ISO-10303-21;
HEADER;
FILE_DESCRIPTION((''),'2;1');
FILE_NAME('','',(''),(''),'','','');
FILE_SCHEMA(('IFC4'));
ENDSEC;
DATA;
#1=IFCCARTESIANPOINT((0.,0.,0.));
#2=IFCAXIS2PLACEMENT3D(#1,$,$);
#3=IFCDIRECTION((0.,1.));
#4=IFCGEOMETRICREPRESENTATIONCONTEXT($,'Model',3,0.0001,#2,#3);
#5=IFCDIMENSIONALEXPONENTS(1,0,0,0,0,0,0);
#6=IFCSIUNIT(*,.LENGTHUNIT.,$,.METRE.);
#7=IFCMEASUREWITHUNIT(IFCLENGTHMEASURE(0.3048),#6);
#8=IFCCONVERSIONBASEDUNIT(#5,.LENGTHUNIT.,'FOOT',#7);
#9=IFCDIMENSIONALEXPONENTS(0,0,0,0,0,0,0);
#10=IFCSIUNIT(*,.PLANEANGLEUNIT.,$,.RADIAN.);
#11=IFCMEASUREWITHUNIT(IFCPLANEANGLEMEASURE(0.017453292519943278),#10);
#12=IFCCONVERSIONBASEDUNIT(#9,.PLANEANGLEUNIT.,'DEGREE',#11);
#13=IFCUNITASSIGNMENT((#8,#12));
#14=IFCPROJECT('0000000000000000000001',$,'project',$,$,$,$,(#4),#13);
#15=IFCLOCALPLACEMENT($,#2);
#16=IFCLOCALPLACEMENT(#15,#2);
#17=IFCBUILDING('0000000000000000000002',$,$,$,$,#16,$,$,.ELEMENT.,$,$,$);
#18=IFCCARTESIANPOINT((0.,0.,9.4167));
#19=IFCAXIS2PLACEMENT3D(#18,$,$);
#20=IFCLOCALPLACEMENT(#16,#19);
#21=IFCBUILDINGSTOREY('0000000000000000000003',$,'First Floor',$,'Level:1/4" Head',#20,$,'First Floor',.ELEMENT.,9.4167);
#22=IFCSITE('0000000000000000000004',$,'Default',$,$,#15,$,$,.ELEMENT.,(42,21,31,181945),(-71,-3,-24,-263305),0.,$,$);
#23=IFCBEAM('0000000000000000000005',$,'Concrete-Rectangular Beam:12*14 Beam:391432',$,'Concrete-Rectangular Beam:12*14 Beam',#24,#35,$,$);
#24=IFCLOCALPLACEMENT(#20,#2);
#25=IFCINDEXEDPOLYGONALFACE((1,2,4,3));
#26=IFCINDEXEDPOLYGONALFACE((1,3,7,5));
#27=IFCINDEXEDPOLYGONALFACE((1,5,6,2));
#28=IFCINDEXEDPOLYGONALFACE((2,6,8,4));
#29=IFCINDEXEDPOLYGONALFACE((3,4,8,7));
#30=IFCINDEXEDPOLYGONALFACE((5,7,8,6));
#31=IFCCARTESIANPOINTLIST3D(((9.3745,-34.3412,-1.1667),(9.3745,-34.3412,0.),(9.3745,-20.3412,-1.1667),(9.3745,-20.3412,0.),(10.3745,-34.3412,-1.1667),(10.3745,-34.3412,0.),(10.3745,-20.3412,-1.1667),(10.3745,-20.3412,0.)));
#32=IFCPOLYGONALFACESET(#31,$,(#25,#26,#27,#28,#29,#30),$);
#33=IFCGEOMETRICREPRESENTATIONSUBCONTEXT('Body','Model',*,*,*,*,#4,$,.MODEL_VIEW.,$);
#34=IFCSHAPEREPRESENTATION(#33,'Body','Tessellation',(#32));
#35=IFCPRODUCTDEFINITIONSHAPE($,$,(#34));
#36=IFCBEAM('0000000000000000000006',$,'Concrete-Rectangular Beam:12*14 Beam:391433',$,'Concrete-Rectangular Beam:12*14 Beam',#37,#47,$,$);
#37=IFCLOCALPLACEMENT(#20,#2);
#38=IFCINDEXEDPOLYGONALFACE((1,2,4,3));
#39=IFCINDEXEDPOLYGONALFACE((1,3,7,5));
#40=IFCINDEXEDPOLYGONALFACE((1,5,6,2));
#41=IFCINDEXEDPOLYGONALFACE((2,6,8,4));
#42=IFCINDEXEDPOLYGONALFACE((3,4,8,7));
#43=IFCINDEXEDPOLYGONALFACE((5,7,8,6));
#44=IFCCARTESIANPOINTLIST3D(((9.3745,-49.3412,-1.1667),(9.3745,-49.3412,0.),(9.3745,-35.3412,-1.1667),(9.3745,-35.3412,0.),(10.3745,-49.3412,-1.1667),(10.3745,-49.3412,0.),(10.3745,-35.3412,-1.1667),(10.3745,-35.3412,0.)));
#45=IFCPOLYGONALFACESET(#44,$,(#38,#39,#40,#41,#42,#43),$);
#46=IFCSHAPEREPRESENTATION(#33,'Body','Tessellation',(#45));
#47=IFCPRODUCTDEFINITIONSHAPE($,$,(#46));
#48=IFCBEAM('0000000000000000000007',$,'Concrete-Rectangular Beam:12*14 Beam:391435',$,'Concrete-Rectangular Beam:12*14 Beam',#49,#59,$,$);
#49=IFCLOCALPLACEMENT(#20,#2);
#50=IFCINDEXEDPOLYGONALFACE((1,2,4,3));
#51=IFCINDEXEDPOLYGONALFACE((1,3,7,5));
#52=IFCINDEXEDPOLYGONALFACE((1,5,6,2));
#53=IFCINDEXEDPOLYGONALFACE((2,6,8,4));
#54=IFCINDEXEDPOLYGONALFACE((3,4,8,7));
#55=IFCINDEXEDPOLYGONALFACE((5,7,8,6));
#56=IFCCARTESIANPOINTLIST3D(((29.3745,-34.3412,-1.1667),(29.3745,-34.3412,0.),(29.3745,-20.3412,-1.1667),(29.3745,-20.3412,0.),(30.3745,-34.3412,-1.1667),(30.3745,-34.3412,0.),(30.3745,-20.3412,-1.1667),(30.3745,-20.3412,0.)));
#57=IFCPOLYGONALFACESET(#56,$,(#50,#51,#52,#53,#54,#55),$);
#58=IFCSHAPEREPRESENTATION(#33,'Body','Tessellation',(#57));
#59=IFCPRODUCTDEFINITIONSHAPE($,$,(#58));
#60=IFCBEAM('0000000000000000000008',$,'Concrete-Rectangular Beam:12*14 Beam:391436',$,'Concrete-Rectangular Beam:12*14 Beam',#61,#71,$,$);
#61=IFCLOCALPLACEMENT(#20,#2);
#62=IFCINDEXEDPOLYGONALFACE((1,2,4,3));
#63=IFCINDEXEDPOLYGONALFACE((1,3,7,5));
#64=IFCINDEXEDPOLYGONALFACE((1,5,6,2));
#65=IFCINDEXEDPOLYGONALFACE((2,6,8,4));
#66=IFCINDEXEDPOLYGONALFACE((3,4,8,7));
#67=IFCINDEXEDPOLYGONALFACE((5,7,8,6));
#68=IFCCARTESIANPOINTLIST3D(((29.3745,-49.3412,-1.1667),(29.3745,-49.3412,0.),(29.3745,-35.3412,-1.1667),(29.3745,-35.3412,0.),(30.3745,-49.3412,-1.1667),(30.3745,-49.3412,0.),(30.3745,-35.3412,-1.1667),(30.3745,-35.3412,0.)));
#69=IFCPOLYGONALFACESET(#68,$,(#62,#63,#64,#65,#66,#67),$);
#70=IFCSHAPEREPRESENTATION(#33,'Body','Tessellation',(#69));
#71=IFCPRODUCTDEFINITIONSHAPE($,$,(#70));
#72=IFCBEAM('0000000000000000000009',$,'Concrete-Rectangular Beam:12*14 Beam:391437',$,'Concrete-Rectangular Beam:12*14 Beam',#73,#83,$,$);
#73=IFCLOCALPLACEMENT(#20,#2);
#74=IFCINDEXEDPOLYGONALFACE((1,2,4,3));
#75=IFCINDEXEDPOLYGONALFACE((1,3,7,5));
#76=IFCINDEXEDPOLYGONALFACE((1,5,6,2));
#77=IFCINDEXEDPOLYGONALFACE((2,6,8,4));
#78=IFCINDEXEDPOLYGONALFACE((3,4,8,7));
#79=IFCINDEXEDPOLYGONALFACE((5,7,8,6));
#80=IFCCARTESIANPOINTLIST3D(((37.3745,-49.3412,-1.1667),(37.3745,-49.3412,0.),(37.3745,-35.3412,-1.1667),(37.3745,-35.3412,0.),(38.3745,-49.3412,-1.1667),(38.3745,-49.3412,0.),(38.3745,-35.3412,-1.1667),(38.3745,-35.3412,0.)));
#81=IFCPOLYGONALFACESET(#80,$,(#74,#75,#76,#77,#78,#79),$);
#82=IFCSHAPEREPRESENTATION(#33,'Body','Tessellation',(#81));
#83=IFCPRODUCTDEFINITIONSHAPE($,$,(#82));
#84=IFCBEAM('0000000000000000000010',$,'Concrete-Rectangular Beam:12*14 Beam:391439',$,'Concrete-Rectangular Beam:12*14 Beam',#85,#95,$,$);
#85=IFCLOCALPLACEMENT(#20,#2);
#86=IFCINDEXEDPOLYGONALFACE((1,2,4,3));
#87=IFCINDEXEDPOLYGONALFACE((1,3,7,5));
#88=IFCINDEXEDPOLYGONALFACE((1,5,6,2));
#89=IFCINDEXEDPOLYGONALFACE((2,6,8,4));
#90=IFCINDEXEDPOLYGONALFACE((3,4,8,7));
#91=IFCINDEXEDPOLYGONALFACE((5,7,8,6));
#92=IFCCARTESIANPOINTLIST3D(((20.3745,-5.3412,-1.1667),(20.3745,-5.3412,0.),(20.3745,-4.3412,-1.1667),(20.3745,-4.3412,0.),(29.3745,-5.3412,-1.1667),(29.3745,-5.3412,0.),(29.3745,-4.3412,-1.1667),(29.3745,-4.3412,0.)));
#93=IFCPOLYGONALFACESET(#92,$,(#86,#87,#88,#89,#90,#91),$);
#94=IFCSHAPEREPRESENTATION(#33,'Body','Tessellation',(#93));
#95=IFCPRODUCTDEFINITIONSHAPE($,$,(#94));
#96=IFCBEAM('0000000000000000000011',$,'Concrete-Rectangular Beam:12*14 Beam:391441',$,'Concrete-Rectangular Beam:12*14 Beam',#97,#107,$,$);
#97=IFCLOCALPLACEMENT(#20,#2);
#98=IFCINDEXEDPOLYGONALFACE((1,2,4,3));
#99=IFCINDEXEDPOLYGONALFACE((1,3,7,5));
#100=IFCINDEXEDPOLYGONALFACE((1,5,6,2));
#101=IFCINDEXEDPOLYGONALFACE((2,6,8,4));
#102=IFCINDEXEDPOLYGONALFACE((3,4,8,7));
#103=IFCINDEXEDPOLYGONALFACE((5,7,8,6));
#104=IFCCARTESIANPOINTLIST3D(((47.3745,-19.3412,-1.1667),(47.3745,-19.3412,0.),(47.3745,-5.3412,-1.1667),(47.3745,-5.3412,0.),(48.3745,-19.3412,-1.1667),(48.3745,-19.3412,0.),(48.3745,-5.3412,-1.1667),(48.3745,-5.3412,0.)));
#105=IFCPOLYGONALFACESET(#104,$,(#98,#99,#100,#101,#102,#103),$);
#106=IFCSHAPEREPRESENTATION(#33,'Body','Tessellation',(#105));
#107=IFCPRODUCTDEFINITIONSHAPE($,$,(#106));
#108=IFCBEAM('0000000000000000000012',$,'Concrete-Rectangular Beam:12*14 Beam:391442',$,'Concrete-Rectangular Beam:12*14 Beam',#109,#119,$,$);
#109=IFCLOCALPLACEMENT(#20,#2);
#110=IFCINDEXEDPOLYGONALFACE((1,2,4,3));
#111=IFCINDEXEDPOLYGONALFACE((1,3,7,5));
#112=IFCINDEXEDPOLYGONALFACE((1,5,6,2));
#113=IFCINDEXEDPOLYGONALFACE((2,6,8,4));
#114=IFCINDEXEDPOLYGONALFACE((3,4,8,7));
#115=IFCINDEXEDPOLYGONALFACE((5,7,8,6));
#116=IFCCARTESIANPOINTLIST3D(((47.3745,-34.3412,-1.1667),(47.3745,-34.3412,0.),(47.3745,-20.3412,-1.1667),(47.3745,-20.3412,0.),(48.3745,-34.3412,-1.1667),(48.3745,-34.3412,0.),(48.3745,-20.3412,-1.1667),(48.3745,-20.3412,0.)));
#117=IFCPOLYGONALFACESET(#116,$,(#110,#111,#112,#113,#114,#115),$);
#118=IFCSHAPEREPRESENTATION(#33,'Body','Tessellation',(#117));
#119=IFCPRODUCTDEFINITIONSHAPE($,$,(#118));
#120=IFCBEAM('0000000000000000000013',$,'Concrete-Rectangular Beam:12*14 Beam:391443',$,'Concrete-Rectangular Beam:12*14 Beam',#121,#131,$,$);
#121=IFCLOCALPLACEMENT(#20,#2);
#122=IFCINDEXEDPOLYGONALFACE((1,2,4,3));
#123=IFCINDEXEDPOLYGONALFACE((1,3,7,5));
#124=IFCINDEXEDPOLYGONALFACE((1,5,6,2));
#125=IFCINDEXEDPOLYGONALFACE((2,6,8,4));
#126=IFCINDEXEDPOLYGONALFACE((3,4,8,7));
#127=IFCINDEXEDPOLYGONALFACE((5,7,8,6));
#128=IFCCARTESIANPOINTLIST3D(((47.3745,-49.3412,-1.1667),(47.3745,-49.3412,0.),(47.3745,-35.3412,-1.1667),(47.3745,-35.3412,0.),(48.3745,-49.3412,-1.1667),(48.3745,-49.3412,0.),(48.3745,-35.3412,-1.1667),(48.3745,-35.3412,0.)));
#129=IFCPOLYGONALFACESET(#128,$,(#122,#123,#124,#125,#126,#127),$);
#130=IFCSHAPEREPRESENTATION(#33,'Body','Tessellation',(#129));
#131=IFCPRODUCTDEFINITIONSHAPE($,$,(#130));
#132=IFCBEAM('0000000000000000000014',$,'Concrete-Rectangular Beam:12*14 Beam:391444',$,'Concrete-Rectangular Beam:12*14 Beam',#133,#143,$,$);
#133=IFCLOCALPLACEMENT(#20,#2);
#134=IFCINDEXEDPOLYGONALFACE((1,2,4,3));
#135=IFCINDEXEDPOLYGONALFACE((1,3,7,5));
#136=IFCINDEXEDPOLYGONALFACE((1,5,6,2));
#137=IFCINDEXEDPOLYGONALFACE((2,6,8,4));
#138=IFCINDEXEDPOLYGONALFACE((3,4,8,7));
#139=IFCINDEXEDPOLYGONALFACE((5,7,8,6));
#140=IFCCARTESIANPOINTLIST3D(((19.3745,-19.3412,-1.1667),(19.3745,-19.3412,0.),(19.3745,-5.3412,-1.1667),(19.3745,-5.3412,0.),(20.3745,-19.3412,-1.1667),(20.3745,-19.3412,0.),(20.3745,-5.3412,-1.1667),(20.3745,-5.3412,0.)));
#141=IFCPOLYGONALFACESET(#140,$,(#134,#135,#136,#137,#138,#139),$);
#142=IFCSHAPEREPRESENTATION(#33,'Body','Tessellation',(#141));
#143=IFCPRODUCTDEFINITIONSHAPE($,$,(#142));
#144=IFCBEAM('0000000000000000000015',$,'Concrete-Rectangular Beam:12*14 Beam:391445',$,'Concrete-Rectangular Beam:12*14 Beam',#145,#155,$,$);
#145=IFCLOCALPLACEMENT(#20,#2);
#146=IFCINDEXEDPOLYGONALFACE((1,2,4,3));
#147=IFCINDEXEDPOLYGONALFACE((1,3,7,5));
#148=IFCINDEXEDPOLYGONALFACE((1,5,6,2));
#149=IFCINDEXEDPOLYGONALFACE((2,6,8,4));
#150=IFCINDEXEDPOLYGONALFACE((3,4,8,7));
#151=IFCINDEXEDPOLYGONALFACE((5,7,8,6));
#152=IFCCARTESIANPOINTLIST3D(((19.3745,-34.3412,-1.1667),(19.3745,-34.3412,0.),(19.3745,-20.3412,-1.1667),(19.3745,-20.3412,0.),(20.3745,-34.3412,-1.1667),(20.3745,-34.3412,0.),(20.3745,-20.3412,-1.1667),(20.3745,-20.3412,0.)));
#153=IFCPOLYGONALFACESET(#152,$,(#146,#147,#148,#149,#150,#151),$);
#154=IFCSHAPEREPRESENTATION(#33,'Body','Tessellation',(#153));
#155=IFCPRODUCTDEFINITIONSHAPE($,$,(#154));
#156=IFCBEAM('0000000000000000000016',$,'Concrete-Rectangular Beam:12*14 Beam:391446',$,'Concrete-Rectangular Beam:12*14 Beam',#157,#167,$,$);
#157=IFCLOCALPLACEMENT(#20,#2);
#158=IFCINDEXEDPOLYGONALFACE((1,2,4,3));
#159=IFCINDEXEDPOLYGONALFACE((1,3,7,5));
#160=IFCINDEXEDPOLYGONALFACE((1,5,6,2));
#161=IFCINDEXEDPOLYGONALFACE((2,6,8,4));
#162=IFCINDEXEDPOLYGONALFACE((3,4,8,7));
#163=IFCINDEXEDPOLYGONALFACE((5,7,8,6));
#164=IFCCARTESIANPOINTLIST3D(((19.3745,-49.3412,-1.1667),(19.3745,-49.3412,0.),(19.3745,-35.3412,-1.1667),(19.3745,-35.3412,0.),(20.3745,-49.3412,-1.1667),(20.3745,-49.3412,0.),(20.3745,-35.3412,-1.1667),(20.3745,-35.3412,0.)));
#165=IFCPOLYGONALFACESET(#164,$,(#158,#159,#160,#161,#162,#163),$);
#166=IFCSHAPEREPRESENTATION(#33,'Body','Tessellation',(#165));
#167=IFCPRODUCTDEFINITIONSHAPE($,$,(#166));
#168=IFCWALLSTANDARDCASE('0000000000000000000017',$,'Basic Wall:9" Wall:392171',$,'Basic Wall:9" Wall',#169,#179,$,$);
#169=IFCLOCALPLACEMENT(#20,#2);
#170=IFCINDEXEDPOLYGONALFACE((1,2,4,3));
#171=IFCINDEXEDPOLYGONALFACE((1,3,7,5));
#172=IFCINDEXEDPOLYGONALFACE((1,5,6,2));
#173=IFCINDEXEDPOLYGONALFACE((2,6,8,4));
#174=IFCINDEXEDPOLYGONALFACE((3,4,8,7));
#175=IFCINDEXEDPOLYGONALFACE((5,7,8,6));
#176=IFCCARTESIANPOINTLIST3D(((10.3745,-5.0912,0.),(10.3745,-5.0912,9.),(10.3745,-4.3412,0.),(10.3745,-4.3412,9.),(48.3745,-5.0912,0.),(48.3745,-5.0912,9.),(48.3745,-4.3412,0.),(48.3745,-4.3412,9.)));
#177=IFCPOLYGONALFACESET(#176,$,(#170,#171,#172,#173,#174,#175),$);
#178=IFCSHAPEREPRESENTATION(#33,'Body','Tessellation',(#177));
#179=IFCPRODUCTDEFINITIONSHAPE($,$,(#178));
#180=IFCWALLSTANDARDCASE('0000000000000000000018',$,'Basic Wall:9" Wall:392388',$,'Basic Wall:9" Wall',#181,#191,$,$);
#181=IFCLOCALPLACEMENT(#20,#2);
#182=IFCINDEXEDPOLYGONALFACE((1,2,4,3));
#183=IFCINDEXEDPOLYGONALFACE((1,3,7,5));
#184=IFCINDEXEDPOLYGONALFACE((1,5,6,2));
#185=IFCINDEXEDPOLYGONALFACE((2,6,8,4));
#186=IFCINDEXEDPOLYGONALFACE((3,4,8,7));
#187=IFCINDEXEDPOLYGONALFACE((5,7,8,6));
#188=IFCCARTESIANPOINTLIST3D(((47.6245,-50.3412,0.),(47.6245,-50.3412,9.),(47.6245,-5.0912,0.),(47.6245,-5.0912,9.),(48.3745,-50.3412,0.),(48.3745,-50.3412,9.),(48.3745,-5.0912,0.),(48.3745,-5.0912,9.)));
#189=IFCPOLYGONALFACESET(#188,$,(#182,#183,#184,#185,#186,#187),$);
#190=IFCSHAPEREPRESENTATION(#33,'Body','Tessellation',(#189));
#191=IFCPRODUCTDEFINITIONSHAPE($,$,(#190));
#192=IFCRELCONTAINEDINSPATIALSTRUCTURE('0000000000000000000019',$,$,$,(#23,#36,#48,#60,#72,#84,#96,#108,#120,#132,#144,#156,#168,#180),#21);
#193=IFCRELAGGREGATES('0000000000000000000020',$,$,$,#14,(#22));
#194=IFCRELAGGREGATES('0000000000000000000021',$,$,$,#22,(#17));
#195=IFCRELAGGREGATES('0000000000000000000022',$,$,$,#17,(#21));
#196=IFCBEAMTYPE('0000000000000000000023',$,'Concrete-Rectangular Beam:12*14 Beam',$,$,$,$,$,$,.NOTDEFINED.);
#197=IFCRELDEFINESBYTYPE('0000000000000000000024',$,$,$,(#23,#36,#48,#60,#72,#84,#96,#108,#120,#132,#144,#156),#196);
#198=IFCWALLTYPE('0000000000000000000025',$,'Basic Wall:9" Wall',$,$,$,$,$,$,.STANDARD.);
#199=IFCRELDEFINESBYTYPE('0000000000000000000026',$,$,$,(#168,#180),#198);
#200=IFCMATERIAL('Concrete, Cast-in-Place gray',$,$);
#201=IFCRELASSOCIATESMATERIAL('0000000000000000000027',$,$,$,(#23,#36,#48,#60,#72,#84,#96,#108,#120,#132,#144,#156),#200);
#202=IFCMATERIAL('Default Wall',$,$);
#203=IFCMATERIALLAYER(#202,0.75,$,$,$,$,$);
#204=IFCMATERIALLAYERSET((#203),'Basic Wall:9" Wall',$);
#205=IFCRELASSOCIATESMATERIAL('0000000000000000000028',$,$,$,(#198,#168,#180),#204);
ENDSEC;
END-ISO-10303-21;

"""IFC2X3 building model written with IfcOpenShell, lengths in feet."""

from ifc_helpers import new_model, entity, si_unit, converted_unit, direction, frame, frame_2d, origin, place, context, subcontext, project, spatial, rectangle, extrude, material, layer, layer_set, layer_usage, type_object, element, save


model = new_model("IFC2X3")

# Units and contexts
model_context = context("Model", 3, precision=0.0001, world=origin(), true_north=direction((0.0, 1.0)))
body_context = subcontext(model_context, "Body", "Model", "MODEL_VIEW")
ifc_project = project(units=[converted_unit("LENGTHUNIT", "FOOT", entity("IfcLengthMeasure", 0.3048), si_unit("LENGTHUNIT", "METRE"), dimensions=[1, 0, 0, 0, 0, 0, 0]), converted_unit("PLANEANGLEUNIT", "DEGREE", entity("IfcPlaneAngleMeasure", 0.017453292519943278), si_unit("PLANEANGLEUNIT", "RADIAN"), dimensions=[0, 0, 0, 0, 0, 0, 0])], contexts=[model_context])

# Site, building, storey
site_placement = place(None, origin())
site = spatial("IfcSite", under=ifc_project, at=site_placement, Name="Default", CompositionType="ELEMENT", RefLatitude=(42, 21, 31, 181945), RefLongitude=(-71, -3, -24, -263305), RefElevation=0.0)
building_placement = place(site_placement, origin())
building = spatial("IfcBuilding", under=site, at=building_placement, CompositionType="ELEMENT")
storey_placement = place(building_placement, frame((0.0, 0.0, 9.4167)))
storey = spatial("IfcBuildingStorey", under=building, at=storey_placement, Name="First Floor", ObjectType="Level:1/4\" Head", LongName="First Floor", CompositionType="ELEMENT", Elevation=9.4167)

# Shared definitions
ifc_material_1 = material(Name="Concrete, Cast-in-Place gray")

# Beams
beam_type = type_object("IfcBeamType", Name="Concrete-Rectangular Beam:12*14 Beam", PredefinedType="NOTDEFINED")
beam_1_placement = place(storey_placement, frame((9.8745, -19.8412, 0.0), z_axis=(0.0, 0.0, 1.0), x_axis=(0.0, -1.0, 0.0)))
element("IfcBeam", 1, at=beam_1_placement, inside=storey, type_object=beam_type, material=ifc_material_1, Name="Concrete-Rectangular Beam:12*14 Beam:391432", ObjectType="Concrete-Rectangular Beam:12*14 Beam", context=body_context, shape_type="SweptSolid", body=[
    extrude(rectangle(XDim=1.1667, YDim=1.0, at=frame_2d((0.0, 0.0), x_axis=(1.0, 0.0))), frame((0.5, 0.0, -0.5833), z_axis=(1.0, 0.0, 0.0), x_axis=(0.0, 0.0, -1.0)), (0.0, 0.0, 1.0), 14.0),
])
beam_2_placement = place(storey_placement, frame((9.8745, -34.8412, 0.0), z_axis=(0.0, 0.0, 1.0), x_axis=(0.0, -1.0, 0.0)))
element("IfcBeam", 2, at=beam_2_placement, inside=storey, type_object=beam_type, material=ifc_material_1, Name="Concrete-Rectangular Beam:12*14 Beam:391433", ObjectType="Concrete-Rectangular Beam:12*14 Beam", context=body_context, shape_type="SweptSolid", body=[
    extrude(rectangle(XDim=1.1667, YDim=1.0, at=frame_2d((0.0, 0.0), x_axis=(1.0, 0.0))), frame((0.5, 0.0, -0.5833), z_axis=(1.0, 0.0, 0.0), x_axis=(0.0, 0.0, -1.0)), (0.0, 0.0, 1.0), 14.0),
])
beam_3_placement = place(storey_placement, frame((29.8745, -19.8412, 0.0), z_axis=(0.0, 0.0, 1.0), x_axis=(0.0, -1.0, 0.0)))
element("IfcBeam", 3, at=beam_3_placement, inside=storey, type_object=beam_type, material=ifc_material_1, Name="Concrete-Rectangular Beam:12*14 Beam:391435", ObjectType="Concrete-Rectangular Beam:12*14 Beam", context=body_context, shape_type="SweptSolid", body=[
    extrude(rectangle(XDim=1.1667, YDim=1.0, at=frame_2d((0.0, 0.0), x_axis=(1.0, 0.0))), frame((0.5, 0.0, -0.5833), z_axis=(1.0, 0.0, 0.0), x_axis=(0.0, 0.0, -1.0)), (0.0, 0.0, 1.0), 14.0),
])
beam_4_placement = place(storey_placement, frame((29.8745, -34.8412, 0.0), z_axis=(0.0, 0.0, 1.0), x_axis=(0.0, -1.0, 0.0)))
element("IfcBeam", 4, at=beam_4_placement, inside=storey, type_object=beam_type, material=ifc_material_1, Name="Concrete-Rectangular Beam:12*14 Beam:391436", ObjectType="Concrete-Rectangular Beam:12*14 Beam", context=body_context, shape_type="SweptSolid", body=[
    extrude(rectangle(XDim=1.1667, YDim=1.0, at=frame_2d((0.0, 0.0), x_axis=(1.0, 0.0))), frame((0.5, 0.0, -0.5833), z_axis=(1.0, 0.0, 0.0), x_axis=(0.0, 0.0, -1.0)), (0.0, 0.0, 1.0), 14.0),
])
beam_5_placement = place(storey_placement, frame((37.8745, -34.8412, 0.0), z_axis=(0.0, 0.0, 1.0), x_axis=(0.0, -1.0, 0.0)))
element("IfcBeam", 5, at=beam_5_placement, inside=storey, type_object=beam_type, material=ifc_material_1, Name="Concrete-Rectangular Beam:12*14 Beam:391437", ObjectType="Concrete-Rectangular Beam:12*14 Beam", context=body_context, shape_type="SweptSolid", body=[
    extrude(rectangle(XDim=1.1667, YDim=1.0, at=frame_2d((0.0, 0.0), x_axis=(1.0, 0.0))), frame((0.5, 0.0, -0.5833), z_axis=(1.0, 0.0, 0.0), x_axis=(0.0, 0.0, -1.0)), (0.0, 0.0, 1.0), 14.0),
])
beam_6_placement = place(storey_placement, frame((19.8745, -4.8412, 0.0)))
element("IfcBeam", 6, at=beam_6_placement, inside=storey, type_object=beam_type, material=ifc_material_1, Name="Concrete-Rectangular Beam:12*14 Beam:391439", ObjectType="Concrete-Rectangular Beam:12*14 Beam", context=body_context, shape_type="SweptSolid", body=[
    extrude(rectangle(XDim=1.1667, YDim=1.0, at=frame_2d((0.0, 0.0), x_axis=(1.0, 0.0))), frame((0.5, 0.0, -0.5833), z_axis=(1.0, 0.0, 0.0), x_axis=(0.0, 0.0, -1.0)), (0.0, 0.0, 1.0), 9.0),
])
beam_7_placement = place(storey_placement, frame((47.8745, -4.8412, 0.0), z_axis=(0.0, 0.0, 1.0), x_axis=(0.0, -1.0, 0.0)))
element("IfcBeam", 7, at=beam_7_placement, inside=storey, type_object=beam_type, material=ifc_material_1, Name="Concrete-Rectangular Beam:12*14 Beam:391441", ObjectType="Concrete-Rectangular Beam:12*14 Beam", context=body_context, shape_type="SweptSolid", body=[
    extrude(rectangle(XDim=1.1667, YDim=1.0, at=frame_2d((0.0, 0.0), x_axis=(1.0, 0.0))), frame((0.5, 0.0, -0.5833), z_axis=(1.0, 0.0, 0.0), x_axis=(0.0, 0.0, -1.0)), (0.0, 0.0, 1.0), 14.0),
])
beam_8_placement = place(storey_placement, frame((47.8745, -19.8412, 0.0), z_axis=(0.0, 0.0, 1.0), x_axis=(0.0, -1.0, 0.0)))
element("IfcBeam", 8, at=beam_8_placement, inside=storey, type_object=beam_type, material=ifc_material_1, Name="Concrete-Rectangular Beam:12*14 Beam:391442", ObjectType="Concrete-Rectangular Beam:12*14 Beam", context=body_context, shape_type="SweptSolid", body=[
    extrude(rectangle(XDim=1.1667, YDim=1.0, at=frame_2d((0.0, 0.0), x_axis=(1.0, 0.0))), frame((0.5, 0.0, -0.5833), z_axis=(1.0, 0.0, 0.0), x_axis=(0.0, 0.0, -1.0)), (0.0, 0.0, 1.0), 14.0),
])
beam_9_placement = place(storey_placement, frame((47.8745, -34.8412, 0.0), z_axis=(0.0, 0.0, 1.0), x_axis=(0.0, -1.0, 0.0)))
element("IfcBeam", 9, at=beam_9_placement, inside=storey, type_object=beam_type, material=ifc_material_1, Name="Concrete-Rectangular Beam:12*14 Beam:391443", ObjectType="Concrete-Rectangular Beam:12*14 Beam", context=body_context, shape_type="SweptSolid", body=[
    extrude(rectangle(XDim=1.1667, YDim=1.0, at=frame_2d((0.0, 0.0), x_axis=(1.0, 0.0))), frame((0.5, 0.0, -0.5833), z_axis=(1.0, 0.0, 0.0), x_axis=(0.0, 0.0, -1.0)), (0.0, 0.0, 1.0), 14.0),
])
beam_10_placement = place(storey_placement, frame((19.8745, -4.8412, 0.0), z_axis=(0.0, 0.0, 1.0), x_axis=(0.0, -1.0, 0.0)))
element("IfcBeam", 10, at=beam_10_placement, inside=storey, type_object=beam_type, material=ifc_material_1, Name="Concrete-Rectangular Beam:12*14 Beam:391444", ObjectType="Concrete-Rectangular Beam:12*14 Beam", context=body_context, shape_type="SweptSolid", body=[
    extrude(rectangle(XDim=1.1667, YDim=1.0, at=frame_2d((0.0, 0.0), x_axis=(1.0, 0.0))), frame((0.5, 0.0, -0.5833), z_axis=(1.0, 0.0, 0.0), x_axis=(0.0, 0.0, -1.0)), (0.0, 0.0, 1.0), 14.0),
])
beam_11_placement = place(storey_placement, frame((19.8745, -19.8412, 0.0), z_axis=(0.0, 0.0, 1.0), x_axis=(0.0, -1.0, 0.0)))
element("IfcBeam", 11, at=beam_11_placement, inside=storey, type_object=beam_type, material=ifc_material_1, Name="Concrete-Rectangular Beam:12*14 Beam:391445", ObjectType="Concrete-Rectangular Beam:12*14 Beam", context=body_context, shape_type="SweptSolid", body=[
    extrude(rectangle(XDim=1.1667, YDim=1.0, at=frame_2d((0.0, 0.0), x_axis=(1.0, 0.0))), frame((0.5, 0.0, -0.5833), z_axis=(1.0, 0.0, 0.0), x_axis=(0.0, 0.0, -1.0)), (0.0, 0.0, 1.0), 14.0),
])
beam_12_placement = place(storey_placement, frame((19.8745, -34.8412, 0.0), z_axis=(0.0, 0.0, 1.0), x_axis=(0.0, -1.0, 0.0)))
element("IfcBeam", 12, at=beam_12_placement, inside=storey, type_object=beam_type, material=ifc_material_1, Name="Concrete-Rectangular Beam:12*14 Beam:391446", ObjectType="Concrete-Rectangular Beam:12*14 Beam", context=body_context, shape_type="SweptSolid", body=[
    extrude(rectangle(XDim=1.1667, YDim=1.0, at=frame_2d((0.0, 0.0), x_axis=(1.0, 0.0))), frame((0.5, 0.0, -0.5833), z_axis=(1.0, 0.0, 0.0), x_axis=(0.0, 0.0, -1.0)), (0.0, 0.0, 1.0), 14.0),
])

# Walls
ifc_material_2 = material(Name="Default Wall")
ifc_layer_1 = layer(ifc_material_2, 0.75)
ifc_layer_set_1 = layer_set([ifc_layer_1], Name="Basic Wall:9\" Wall")
ifc_layer_usage_1 = layer_usage(ifc_layer_set_1, "AXIS2", "NEGATIVE", 0.375)
wall_type_1 = type_object("IfcWallType", Name="Basic Wall:9\" Wall", PredefinedType="STANDARD", material=ifc_layer_set_1)
wall_1_placement = place(storey_placement, frame((10.3745, -4.7162, 0.0)))
element("IfcWallStandardCase", 13, at=wall_1_placement, inside=storey, type_object=wall_type_1, material=ifc_layer_usage_1, Name="Basic Wall:9\" Wall:392171", ObjectType="Basic Wall:9\" Wall", context=body_context, shape_type="SweptSolid", body=[
    extrude(rectangle(XDim=38.0, YDim=0.75, at=frame_2d((19.0, 0.0), x_axis=(-1.0, 0.0))), origin(), (0.0, 0.0, 1.0), 9.0),
])
wall_2_placement = place(storey_placement, frame((47.9995, -5.0912, 0.0), z_axis=(0.0, 0.0, 1.0), x_axis=(0.0, -1.0, 0.0)))
element("IfcWallStandardCase", 14, at=wall_2_placement, inside=storey, type_object=wall_type_1, material=ifc_layer_usage_1, Name="Basic Wall:9\" Wall:392388", ObjectType="Basic Wall:9\" Wall", context=body_context, shape_type="SweptSolid", body=[
    extrude(rectangle(XDim=45.25, YDim=0.75, at=frame_2d((22.625, 0.0), x_axis=(-1.0, 0.0))), origin(), (0.0, 0.0, 1.0), 9.0),
])

save(model, "model.ifc")
